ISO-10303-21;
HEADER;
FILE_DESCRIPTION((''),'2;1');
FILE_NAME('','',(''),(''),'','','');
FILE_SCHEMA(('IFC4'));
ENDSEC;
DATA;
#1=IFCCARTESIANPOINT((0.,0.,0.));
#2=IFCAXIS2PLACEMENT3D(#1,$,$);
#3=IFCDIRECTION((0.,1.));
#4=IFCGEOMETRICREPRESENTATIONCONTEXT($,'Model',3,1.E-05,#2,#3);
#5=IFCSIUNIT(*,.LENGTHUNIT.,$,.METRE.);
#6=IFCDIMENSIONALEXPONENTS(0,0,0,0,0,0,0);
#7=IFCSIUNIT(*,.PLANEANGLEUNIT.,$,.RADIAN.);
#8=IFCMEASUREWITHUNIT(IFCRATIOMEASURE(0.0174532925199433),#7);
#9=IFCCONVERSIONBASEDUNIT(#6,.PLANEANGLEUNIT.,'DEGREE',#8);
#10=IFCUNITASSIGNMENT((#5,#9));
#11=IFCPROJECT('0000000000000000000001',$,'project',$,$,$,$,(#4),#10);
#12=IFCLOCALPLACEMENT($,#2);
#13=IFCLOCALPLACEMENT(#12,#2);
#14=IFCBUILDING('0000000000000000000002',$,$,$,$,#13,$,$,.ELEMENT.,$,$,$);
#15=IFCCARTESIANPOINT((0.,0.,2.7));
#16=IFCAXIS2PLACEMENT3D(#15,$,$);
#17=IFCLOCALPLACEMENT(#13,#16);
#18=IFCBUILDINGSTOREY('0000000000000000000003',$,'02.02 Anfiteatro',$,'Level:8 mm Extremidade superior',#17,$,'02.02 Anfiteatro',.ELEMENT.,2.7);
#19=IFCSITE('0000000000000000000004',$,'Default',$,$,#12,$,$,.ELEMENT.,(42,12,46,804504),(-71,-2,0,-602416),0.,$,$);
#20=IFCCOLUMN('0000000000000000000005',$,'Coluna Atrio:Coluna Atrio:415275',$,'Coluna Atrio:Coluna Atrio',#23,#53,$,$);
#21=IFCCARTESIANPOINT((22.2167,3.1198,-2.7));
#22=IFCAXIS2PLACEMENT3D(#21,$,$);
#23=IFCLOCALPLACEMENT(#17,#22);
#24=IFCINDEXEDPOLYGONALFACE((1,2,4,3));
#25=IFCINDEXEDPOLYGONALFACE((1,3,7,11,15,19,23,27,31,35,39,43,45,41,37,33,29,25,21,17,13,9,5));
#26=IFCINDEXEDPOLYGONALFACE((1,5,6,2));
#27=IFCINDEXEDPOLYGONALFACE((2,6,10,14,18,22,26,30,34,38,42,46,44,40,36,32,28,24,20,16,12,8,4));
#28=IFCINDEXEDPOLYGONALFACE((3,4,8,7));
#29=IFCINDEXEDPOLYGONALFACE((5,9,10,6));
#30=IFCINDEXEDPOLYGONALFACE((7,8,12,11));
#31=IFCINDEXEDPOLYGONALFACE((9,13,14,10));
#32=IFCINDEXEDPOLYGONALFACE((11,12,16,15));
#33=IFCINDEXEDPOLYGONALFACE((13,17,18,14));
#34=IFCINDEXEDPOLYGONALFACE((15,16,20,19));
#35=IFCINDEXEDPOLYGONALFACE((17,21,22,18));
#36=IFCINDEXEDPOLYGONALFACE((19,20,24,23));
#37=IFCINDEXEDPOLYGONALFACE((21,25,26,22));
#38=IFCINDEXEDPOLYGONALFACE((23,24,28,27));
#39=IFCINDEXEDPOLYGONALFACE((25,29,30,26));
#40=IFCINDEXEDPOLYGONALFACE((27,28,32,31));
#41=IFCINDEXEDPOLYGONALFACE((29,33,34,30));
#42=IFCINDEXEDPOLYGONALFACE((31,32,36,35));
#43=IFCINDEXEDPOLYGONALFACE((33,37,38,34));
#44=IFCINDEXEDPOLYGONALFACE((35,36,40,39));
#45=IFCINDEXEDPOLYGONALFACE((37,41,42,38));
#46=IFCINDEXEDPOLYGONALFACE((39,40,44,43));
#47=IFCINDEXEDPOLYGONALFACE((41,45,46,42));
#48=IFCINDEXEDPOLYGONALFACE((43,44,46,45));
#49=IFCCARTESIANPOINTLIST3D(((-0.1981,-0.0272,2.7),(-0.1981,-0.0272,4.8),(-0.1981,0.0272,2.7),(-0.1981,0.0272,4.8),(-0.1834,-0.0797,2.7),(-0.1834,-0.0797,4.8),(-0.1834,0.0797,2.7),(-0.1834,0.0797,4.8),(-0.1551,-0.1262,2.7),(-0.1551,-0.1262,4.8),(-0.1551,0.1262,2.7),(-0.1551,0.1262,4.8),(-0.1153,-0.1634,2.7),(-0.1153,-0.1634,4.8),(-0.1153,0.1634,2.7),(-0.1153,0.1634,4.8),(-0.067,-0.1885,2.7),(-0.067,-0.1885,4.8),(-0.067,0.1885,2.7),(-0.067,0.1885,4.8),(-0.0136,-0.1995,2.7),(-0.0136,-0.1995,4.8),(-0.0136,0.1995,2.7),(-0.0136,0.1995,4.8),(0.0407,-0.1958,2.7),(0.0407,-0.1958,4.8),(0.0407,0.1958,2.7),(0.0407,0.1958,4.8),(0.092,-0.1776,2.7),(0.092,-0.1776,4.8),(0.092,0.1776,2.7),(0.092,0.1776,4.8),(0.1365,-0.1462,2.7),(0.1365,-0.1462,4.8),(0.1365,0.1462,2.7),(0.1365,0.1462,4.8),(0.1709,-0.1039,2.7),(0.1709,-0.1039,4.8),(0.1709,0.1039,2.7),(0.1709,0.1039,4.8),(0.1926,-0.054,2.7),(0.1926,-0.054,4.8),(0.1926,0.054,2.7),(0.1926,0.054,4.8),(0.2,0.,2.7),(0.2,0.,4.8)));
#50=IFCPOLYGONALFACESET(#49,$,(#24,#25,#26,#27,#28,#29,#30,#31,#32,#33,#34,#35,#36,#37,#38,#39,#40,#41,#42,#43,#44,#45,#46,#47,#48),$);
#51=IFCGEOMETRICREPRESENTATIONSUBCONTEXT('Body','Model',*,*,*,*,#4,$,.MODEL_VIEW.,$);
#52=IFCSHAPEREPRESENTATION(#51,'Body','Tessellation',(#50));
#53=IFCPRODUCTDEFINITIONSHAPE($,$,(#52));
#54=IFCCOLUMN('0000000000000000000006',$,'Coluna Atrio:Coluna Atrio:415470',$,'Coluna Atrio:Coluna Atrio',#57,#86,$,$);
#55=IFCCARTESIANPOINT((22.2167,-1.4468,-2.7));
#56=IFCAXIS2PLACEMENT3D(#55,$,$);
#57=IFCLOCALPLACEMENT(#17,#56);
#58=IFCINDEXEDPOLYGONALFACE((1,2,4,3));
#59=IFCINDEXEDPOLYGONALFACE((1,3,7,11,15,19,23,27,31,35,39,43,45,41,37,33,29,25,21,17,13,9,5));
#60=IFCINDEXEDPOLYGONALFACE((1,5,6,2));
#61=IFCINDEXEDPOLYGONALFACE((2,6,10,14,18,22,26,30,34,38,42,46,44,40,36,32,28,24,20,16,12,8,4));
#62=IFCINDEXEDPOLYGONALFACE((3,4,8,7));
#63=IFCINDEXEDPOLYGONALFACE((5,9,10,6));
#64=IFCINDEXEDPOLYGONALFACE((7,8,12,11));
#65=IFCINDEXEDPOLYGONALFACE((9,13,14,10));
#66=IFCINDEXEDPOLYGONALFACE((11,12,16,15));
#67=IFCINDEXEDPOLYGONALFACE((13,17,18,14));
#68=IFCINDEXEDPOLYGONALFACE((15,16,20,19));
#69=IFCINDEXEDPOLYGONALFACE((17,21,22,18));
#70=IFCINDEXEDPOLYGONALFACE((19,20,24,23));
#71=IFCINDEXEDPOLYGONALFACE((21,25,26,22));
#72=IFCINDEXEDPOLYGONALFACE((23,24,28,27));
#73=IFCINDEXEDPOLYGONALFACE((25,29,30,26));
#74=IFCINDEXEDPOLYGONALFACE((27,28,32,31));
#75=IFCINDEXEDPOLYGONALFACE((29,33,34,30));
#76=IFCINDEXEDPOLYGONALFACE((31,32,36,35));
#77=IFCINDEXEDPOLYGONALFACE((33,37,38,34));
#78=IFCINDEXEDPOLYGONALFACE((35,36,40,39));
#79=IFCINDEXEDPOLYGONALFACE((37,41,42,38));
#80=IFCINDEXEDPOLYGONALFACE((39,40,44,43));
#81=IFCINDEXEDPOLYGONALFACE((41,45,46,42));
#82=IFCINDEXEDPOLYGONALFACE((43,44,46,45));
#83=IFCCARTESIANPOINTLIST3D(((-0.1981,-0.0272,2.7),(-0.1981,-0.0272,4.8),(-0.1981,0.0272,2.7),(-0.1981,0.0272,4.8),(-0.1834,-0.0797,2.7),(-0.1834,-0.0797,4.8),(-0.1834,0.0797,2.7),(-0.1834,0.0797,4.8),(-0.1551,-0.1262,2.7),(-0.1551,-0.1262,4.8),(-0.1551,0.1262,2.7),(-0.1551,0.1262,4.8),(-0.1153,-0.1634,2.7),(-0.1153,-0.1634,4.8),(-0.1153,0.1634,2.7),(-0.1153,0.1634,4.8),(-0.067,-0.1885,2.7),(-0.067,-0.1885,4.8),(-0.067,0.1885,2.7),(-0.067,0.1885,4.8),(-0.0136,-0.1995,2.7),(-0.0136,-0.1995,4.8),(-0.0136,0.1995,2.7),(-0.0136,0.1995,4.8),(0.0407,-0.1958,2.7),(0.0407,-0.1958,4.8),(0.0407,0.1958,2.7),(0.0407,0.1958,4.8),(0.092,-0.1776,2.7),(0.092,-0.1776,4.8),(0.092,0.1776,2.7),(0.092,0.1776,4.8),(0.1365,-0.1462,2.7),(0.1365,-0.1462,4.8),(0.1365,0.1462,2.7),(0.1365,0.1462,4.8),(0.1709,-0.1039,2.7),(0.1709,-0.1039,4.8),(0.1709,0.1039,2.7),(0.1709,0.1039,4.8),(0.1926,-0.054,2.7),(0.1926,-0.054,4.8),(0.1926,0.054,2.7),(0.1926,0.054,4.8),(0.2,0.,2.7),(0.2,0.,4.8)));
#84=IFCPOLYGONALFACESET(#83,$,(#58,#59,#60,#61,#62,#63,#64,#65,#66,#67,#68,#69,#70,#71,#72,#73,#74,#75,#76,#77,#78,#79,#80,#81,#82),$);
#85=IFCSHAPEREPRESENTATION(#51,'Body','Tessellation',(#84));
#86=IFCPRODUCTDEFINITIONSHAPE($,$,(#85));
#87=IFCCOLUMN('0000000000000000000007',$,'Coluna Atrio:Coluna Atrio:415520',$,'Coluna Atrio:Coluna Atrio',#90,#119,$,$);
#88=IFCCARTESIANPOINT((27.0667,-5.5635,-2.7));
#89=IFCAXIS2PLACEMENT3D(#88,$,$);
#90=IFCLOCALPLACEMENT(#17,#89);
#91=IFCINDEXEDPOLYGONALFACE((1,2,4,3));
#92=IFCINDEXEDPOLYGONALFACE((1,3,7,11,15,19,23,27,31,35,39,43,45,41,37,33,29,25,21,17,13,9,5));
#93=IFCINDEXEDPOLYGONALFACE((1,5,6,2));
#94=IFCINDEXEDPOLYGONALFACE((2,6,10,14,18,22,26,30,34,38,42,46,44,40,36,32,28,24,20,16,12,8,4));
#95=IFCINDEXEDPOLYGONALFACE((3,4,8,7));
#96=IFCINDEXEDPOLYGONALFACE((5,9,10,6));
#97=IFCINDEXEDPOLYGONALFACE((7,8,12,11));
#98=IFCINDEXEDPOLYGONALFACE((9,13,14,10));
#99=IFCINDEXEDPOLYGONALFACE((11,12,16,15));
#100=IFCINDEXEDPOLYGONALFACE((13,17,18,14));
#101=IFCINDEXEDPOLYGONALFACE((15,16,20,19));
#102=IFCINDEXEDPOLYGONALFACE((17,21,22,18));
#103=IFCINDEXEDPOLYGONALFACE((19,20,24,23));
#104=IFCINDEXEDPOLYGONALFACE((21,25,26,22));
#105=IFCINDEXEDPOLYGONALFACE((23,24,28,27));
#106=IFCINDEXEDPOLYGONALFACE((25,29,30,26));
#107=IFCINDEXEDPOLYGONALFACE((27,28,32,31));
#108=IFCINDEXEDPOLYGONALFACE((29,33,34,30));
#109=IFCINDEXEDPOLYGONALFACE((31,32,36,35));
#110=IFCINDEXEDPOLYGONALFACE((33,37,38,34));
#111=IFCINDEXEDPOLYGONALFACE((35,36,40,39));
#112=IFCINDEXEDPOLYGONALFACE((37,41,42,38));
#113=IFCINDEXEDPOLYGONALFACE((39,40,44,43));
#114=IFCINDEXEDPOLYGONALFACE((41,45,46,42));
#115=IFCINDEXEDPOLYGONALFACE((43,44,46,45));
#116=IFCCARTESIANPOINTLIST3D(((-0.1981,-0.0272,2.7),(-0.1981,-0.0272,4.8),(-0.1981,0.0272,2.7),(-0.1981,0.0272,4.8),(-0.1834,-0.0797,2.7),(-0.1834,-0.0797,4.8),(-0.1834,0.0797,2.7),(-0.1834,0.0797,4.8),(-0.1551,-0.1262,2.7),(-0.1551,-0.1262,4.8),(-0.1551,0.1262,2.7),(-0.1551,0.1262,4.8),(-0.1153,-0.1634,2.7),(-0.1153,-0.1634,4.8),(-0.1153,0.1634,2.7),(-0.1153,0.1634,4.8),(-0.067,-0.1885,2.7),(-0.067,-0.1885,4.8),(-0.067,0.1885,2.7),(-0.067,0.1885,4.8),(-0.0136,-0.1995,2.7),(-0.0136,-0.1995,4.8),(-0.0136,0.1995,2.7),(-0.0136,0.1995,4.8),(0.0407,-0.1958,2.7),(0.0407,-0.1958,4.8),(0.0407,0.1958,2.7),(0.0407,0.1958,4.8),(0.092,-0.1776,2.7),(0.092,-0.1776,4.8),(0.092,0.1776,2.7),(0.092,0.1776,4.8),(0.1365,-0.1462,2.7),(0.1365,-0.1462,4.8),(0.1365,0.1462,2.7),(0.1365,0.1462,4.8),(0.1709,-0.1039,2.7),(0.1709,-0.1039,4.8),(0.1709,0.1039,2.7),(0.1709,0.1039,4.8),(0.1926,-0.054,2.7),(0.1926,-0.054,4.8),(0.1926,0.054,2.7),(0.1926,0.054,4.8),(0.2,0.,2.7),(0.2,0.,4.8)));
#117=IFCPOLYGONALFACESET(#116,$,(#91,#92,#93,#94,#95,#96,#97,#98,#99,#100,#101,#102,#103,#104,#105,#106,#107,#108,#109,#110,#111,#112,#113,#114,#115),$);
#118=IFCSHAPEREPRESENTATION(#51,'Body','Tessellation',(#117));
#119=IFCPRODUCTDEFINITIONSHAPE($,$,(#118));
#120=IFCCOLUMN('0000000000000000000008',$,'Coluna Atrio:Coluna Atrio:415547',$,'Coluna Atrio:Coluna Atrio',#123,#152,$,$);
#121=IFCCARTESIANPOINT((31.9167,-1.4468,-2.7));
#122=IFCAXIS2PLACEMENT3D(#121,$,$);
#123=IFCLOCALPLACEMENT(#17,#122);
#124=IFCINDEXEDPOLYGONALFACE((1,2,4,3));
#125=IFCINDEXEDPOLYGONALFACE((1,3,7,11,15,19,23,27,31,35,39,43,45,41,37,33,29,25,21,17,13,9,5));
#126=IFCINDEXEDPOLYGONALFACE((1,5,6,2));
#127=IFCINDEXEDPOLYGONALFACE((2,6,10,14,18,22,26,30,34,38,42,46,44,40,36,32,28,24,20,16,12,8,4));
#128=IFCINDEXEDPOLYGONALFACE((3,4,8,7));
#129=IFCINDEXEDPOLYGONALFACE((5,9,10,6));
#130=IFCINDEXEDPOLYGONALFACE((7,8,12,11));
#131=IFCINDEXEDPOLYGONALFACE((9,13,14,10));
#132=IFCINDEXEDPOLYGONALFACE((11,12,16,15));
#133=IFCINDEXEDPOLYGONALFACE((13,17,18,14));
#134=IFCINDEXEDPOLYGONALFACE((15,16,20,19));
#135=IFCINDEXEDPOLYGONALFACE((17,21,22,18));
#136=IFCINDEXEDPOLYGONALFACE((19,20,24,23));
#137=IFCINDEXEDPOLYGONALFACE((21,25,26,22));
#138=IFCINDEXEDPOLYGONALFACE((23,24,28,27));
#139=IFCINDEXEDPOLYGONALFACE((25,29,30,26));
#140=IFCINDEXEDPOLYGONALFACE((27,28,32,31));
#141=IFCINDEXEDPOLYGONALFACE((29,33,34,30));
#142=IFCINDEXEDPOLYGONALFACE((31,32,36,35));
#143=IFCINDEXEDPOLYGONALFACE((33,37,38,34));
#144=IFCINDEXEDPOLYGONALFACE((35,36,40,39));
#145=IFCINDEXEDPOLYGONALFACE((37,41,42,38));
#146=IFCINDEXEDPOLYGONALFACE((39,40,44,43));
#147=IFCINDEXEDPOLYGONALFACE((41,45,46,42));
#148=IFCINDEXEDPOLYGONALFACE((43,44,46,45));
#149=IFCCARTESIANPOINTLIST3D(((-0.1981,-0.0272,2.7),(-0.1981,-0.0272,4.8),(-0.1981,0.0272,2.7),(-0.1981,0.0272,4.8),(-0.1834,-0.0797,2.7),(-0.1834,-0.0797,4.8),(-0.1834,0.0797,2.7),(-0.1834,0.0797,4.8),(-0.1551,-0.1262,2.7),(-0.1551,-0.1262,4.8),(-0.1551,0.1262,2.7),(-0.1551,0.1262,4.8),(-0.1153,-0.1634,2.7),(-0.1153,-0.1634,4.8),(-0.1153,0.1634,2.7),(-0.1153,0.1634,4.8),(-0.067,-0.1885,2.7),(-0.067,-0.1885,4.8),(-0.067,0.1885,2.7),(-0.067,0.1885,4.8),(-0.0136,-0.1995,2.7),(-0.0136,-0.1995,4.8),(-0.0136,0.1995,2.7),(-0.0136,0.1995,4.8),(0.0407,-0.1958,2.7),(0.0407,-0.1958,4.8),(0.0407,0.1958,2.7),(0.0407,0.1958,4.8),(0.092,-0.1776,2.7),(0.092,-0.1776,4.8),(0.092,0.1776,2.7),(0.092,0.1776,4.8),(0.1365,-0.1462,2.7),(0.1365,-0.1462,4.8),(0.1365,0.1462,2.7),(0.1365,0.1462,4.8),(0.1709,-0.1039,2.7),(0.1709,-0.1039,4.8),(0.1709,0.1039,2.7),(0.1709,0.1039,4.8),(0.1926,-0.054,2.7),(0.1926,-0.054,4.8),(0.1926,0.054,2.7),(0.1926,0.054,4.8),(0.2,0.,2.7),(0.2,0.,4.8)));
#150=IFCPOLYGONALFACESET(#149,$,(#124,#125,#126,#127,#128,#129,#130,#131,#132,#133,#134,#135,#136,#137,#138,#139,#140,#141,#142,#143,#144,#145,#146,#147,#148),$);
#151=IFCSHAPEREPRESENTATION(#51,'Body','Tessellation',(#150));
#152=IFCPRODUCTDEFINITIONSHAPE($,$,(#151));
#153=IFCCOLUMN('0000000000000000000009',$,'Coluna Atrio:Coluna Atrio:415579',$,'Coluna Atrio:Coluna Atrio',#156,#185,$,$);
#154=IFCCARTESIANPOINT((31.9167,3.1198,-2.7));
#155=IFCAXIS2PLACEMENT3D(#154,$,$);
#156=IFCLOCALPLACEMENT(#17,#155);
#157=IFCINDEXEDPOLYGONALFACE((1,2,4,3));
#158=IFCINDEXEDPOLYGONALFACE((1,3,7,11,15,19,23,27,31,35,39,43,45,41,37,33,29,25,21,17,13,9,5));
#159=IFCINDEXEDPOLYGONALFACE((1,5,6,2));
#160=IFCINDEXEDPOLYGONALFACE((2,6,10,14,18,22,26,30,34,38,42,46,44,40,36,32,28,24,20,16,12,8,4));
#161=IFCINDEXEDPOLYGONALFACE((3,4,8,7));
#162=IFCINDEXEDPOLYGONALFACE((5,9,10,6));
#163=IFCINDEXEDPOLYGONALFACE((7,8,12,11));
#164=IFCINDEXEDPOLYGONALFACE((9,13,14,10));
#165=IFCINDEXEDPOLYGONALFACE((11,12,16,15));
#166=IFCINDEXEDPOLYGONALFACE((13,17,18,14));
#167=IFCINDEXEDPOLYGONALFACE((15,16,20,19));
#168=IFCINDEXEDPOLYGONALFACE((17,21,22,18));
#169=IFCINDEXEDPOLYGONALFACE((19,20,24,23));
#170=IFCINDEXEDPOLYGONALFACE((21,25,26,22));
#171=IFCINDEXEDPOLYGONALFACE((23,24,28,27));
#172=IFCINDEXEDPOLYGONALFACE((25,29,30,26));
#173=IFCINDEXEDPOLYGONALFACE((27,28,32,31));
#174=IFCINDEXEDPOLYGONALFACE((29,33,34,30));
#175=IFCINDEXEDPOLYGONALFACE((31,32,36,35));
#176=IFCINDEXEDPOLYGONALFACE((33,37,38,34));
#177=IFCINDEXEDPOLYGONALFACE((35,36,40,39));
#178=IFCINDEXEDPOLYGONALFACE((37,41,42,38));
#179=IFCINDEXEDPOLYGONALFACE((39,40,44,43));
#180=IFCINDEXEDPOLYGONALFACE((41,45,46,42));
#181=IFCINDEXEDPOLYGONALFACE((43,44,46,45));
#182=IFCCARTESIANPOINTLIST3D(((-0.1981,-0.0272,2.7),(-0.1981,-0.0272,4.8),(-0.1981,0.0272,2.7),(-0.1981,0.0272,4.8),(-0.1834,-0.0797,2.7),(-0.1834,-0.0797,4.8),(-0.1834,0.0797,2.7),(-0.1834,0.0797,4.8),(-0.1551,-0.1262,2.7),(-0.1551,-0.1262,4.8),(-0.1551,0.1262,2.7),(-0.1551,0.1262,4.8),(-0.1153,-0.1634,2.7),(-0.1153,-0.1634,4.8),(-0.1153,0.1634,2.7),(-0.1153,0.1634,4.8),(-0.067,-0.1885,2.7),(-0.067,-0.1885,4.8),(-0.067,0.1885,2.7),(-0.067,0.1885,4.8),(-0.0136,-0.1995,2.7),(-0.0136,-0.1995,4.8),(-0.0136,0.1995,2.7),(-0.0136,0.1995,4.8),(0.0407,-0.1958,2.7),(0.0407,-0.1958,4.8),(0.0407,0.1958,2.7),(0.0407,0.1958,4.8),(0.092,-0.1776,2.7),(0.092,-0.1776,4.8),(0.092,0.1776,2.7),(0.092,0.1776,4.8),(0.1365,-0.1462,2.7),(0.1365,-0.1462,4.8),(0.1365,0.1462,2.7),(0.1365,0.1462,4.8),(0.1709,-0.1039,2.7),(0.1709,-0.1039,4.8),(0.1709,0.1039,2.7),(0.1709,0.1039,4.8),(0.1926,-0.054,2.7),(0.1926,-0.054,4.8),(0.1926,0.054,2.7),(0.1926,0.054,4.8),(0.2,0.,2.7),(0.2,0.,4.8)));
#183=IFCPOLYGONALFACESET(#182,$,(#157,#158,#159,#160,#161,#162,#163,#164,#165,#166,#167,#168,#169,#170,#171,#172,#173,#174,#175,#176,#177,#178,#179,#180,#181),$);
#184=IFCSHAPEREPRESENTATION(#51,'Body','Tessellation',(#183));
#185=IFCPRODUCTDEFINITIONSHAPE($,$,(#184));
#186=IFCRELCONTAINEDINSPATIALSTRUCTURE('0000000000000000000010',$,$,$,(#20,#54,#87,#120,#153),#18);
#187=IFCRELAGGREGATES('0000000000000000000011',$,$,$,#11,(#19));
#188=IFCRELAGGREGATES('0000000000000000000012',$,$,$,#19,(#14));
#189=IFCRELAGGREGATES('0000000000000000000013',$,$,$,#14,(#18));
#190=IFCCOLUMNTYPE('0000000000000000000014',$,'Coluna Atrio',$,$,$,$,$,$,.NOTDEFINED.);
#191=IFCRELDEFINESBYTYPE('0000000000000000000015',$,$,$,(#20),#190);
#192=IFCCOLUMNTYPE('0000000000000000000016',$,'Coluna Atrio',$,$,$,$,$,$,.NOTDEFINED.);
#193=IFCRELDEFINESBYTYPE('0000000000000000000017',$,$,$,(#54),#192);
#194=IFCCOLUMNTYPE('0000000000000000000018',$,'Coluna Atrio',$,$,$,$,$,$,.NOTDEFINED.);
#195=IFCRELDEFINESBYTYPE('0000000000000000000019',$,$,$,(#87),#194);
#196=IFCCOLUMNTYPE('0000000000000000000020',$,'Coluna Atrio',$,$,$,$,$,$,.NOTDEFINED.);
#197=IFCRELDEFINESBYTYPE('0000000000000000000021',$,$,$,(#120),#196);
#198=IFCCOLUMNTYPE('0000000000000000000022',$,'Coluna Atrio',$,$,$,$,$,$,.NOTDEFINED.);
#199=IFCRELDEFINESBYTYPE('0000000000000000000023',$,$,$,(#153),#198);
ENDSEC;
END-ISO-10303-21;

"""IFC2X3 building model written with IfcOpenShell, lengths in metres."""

from ifc_helpers import new_model, entity, si_unit, converted_unit, direction, frame, frame_2d, origin, place, context, subcontext, project, spatial, circle, extrude, source, transform, mapped, type_object, type_shapes, element, save


model = new_model("IFC2X3")

# Units and contexts
model_context = context("Model", 3, precision=1e-05, world=origin(), true_north=direction((0.0, 1.0)))
body_context = subcontext(model_context, "Body", "Model", "MODEL_VIEW")
ifc_project = project(units=[si_unit("LENGTHUNIT", "METRE"), converted_unit("PLANEANGLEUNIT", "DEGREE", entity("IfcRatioMeasure", 0.0174532925199433), si_unit("PLANEANGLEUNIT", "RADIAN"), dimensions=[0, 0, 0, 0, 0, 0, 0])], contexts=[model_context])

# Site, building, storey
site_placement = place(None, origin())
site = spatial("IfcSite", under=ifc_project, at=site_placement, Name="Default", CompositionType="ELEMENT", RefLatitude=(42, 12, 46, 804504), RefLongitude=(-71, -2, 0, -602416), RefElevation=0.0)
building_placement = place(site_placement, origin())
building = spatial("IfcBuilding", under=site, at=building_placement, CompositionType="ELEMENT")
storey_placement = place(building_placement, frame((0.0, 0.0, 2.7)))
storey = spatial("IfcBuildingStorey", under=building, at=storey_placement, Name="02.02 Anfiteatro", ObjectType="Level:8 mm Extremidade superior", LongName="02.02 Anfiteatro", CompositionType="ELEMENT", Elevation=2.7)

# Columns
column_type_1 = type_object("IfcColumnType", Name="Coluna Atrio", PredefinedType="NOTDEFINED")
shared_shape_1 = source(origin(), body_context, "Body", "SweptSolid", [
    extrude(circle(Radius=0.2, at=frame_2d((0.0, 0.0), x_axis=(1.0, 0.0))), frame((0.0, 0.0, 2.7)), (0.0, 0.0, 1.0), 2.1),
])
type_shapes(column_type_1, [shared_shape_1])
column_1_placement = place(storey_placement, frame((22.2167, 3.1198, -2.7)))
element("IfcColumn", 1, at=column_1_placement, inside=storey, type_object=column_type_1, Name="Coluna Atrio:Coluna Atrio:415275", ObjectType="Coluna Atrio:Coluna Atrio", context=body_context, shape_type="MappedRepresentation", body=[
    mapped(shared_shape_1, transform((0.0, 0.0, 0.0), scale=1.0)),
])
column_type_2 = type_object("IfcColumnType", Name="Coluna Atrio", PredefinedType="NOTDEFINED")
shared_shape_2 = source(origin(), body_context, "Body", "SweptSolid", [
    extrude(circle(Radius=0.2, at=frame_2d((0.0, 0.0), x_axis=(1.0, 0.0))), frame((0.0, 0.0, 2.7)), (0.0, 0.0, 1.0), 2.1),
])
type_shapes(column_type_2, [shared_shape_2])
column_2_placement = place(storey_placement, frame((22.2167, -1.4468, -2.7)))
element("IfcColumn", 2, at=column_2_placement, inside=storey, type_object=column_type_2, Name="Coluna Atrio:Coluna Atrio:415470", ObjectType="Coluna Atrio:Coluna Atrio", context=body_context, shape_type="MappedRepresentation", body=[
    mapped(shared_shape_2, transform((0.0, 0.0, 0.0), scale=1.0)),
])
column_type_3 = type_object("IfcColumnType", Name="Coluna Atrio", PredefinedType="NOTDEFINED")
shared_shape_3 = source(origin(), body_context, "Body", "SweptSolid", [
    extrude(circle(Radius=0.2, at=frame_2d((0.0, 0.0), x_axis=(1.0, 0.0))), frame((0.0, 0.0, 2.7)), (0.0, 0.0, 1.0), 2.1),
])
type_shapes(column_type_3, [shared_shape_3])
column_3_placement = place(storey_placement, frame((27.0667, -5.5635, -2.7)))
element("IfcColumn", 3, at=column_3_placement, inside=storey, type_object=column_type_3, Name="Coluna Atrio:Coluna Atrio:415520", ObjectType="Coluna Atrio:Coluna Atrio", context=body_context, shape_type="MappedRepresentation", body=[
    mapped(shared_shape_3, transform((0.0, 0.0, 0.0), scale=1.0)),
])
column_type_4 = type_object("IfcColumnType", Name="Coluna Atrio", PredefinedType="NOTDEFINED")
shared_shape_4 = source(origin(), body_context, "Body", "SweptSolid", [
    extrude(circle(Radius=0.2, at=frame_2d((0.0, 0.0), x_axis=(1.0, 0.0))), frame((0.0, 0.0, 2.7)), (0.0, 0.0, 1.0), 2.1),
])
type_shapes(column_type_4, [shared_shape_4])
column_4_placement = place(storey_placement, frame((31.9167, -1.4468, -2.7)))
element("IfcColumn", 4, at=column_4_placement, inside=storey, type_object=column_type_4, Name="Coluna Atrio:Coluna Atrio:415547", ObjectType="Coluna Atrio:Coluna Atrio", context=body_context, shape_type="MappedRepresentation", body=[
    mapped(shared_shape_4, transform((0.0, 0.0, 0.0), scale=1.0)),
])
column_type_5 = type_object("IfcColumnType", Name="Coluna Atrio", PredefinedType="NOTDEFINED")
shared_shape_5 = source(origin(), body_context, "Body", "SweptSolid", [
    extrude(circle(Radius=0.2, at=frame_2d((0.0, 0.0), x_axis=(1.0, 0.0))), frame((0.0, 0.0, 2.7)), (0.0, 0.0, 1.0), 2.1),
])
type_shapes(column_type_5, [shared_shape_5])
column_5_placement = place(storey_placement, frame((31.9167, 3.1198, -2.7)))
element("IfcColumn", 5, at=column_5_placement, inside=storey, type_object=column_type_5, Name="Coluna Atrio:Coluna Atrio:415579", ObjectType="Coluna Atrio:Coluna Atrio", context=body_context, shape_type="MappedRepresentation", body=[
    mapped(shared_shape_5, transform((0.0, 0.0, 0.0), scale=1.0)),
])

save(model, "model.ifc")
